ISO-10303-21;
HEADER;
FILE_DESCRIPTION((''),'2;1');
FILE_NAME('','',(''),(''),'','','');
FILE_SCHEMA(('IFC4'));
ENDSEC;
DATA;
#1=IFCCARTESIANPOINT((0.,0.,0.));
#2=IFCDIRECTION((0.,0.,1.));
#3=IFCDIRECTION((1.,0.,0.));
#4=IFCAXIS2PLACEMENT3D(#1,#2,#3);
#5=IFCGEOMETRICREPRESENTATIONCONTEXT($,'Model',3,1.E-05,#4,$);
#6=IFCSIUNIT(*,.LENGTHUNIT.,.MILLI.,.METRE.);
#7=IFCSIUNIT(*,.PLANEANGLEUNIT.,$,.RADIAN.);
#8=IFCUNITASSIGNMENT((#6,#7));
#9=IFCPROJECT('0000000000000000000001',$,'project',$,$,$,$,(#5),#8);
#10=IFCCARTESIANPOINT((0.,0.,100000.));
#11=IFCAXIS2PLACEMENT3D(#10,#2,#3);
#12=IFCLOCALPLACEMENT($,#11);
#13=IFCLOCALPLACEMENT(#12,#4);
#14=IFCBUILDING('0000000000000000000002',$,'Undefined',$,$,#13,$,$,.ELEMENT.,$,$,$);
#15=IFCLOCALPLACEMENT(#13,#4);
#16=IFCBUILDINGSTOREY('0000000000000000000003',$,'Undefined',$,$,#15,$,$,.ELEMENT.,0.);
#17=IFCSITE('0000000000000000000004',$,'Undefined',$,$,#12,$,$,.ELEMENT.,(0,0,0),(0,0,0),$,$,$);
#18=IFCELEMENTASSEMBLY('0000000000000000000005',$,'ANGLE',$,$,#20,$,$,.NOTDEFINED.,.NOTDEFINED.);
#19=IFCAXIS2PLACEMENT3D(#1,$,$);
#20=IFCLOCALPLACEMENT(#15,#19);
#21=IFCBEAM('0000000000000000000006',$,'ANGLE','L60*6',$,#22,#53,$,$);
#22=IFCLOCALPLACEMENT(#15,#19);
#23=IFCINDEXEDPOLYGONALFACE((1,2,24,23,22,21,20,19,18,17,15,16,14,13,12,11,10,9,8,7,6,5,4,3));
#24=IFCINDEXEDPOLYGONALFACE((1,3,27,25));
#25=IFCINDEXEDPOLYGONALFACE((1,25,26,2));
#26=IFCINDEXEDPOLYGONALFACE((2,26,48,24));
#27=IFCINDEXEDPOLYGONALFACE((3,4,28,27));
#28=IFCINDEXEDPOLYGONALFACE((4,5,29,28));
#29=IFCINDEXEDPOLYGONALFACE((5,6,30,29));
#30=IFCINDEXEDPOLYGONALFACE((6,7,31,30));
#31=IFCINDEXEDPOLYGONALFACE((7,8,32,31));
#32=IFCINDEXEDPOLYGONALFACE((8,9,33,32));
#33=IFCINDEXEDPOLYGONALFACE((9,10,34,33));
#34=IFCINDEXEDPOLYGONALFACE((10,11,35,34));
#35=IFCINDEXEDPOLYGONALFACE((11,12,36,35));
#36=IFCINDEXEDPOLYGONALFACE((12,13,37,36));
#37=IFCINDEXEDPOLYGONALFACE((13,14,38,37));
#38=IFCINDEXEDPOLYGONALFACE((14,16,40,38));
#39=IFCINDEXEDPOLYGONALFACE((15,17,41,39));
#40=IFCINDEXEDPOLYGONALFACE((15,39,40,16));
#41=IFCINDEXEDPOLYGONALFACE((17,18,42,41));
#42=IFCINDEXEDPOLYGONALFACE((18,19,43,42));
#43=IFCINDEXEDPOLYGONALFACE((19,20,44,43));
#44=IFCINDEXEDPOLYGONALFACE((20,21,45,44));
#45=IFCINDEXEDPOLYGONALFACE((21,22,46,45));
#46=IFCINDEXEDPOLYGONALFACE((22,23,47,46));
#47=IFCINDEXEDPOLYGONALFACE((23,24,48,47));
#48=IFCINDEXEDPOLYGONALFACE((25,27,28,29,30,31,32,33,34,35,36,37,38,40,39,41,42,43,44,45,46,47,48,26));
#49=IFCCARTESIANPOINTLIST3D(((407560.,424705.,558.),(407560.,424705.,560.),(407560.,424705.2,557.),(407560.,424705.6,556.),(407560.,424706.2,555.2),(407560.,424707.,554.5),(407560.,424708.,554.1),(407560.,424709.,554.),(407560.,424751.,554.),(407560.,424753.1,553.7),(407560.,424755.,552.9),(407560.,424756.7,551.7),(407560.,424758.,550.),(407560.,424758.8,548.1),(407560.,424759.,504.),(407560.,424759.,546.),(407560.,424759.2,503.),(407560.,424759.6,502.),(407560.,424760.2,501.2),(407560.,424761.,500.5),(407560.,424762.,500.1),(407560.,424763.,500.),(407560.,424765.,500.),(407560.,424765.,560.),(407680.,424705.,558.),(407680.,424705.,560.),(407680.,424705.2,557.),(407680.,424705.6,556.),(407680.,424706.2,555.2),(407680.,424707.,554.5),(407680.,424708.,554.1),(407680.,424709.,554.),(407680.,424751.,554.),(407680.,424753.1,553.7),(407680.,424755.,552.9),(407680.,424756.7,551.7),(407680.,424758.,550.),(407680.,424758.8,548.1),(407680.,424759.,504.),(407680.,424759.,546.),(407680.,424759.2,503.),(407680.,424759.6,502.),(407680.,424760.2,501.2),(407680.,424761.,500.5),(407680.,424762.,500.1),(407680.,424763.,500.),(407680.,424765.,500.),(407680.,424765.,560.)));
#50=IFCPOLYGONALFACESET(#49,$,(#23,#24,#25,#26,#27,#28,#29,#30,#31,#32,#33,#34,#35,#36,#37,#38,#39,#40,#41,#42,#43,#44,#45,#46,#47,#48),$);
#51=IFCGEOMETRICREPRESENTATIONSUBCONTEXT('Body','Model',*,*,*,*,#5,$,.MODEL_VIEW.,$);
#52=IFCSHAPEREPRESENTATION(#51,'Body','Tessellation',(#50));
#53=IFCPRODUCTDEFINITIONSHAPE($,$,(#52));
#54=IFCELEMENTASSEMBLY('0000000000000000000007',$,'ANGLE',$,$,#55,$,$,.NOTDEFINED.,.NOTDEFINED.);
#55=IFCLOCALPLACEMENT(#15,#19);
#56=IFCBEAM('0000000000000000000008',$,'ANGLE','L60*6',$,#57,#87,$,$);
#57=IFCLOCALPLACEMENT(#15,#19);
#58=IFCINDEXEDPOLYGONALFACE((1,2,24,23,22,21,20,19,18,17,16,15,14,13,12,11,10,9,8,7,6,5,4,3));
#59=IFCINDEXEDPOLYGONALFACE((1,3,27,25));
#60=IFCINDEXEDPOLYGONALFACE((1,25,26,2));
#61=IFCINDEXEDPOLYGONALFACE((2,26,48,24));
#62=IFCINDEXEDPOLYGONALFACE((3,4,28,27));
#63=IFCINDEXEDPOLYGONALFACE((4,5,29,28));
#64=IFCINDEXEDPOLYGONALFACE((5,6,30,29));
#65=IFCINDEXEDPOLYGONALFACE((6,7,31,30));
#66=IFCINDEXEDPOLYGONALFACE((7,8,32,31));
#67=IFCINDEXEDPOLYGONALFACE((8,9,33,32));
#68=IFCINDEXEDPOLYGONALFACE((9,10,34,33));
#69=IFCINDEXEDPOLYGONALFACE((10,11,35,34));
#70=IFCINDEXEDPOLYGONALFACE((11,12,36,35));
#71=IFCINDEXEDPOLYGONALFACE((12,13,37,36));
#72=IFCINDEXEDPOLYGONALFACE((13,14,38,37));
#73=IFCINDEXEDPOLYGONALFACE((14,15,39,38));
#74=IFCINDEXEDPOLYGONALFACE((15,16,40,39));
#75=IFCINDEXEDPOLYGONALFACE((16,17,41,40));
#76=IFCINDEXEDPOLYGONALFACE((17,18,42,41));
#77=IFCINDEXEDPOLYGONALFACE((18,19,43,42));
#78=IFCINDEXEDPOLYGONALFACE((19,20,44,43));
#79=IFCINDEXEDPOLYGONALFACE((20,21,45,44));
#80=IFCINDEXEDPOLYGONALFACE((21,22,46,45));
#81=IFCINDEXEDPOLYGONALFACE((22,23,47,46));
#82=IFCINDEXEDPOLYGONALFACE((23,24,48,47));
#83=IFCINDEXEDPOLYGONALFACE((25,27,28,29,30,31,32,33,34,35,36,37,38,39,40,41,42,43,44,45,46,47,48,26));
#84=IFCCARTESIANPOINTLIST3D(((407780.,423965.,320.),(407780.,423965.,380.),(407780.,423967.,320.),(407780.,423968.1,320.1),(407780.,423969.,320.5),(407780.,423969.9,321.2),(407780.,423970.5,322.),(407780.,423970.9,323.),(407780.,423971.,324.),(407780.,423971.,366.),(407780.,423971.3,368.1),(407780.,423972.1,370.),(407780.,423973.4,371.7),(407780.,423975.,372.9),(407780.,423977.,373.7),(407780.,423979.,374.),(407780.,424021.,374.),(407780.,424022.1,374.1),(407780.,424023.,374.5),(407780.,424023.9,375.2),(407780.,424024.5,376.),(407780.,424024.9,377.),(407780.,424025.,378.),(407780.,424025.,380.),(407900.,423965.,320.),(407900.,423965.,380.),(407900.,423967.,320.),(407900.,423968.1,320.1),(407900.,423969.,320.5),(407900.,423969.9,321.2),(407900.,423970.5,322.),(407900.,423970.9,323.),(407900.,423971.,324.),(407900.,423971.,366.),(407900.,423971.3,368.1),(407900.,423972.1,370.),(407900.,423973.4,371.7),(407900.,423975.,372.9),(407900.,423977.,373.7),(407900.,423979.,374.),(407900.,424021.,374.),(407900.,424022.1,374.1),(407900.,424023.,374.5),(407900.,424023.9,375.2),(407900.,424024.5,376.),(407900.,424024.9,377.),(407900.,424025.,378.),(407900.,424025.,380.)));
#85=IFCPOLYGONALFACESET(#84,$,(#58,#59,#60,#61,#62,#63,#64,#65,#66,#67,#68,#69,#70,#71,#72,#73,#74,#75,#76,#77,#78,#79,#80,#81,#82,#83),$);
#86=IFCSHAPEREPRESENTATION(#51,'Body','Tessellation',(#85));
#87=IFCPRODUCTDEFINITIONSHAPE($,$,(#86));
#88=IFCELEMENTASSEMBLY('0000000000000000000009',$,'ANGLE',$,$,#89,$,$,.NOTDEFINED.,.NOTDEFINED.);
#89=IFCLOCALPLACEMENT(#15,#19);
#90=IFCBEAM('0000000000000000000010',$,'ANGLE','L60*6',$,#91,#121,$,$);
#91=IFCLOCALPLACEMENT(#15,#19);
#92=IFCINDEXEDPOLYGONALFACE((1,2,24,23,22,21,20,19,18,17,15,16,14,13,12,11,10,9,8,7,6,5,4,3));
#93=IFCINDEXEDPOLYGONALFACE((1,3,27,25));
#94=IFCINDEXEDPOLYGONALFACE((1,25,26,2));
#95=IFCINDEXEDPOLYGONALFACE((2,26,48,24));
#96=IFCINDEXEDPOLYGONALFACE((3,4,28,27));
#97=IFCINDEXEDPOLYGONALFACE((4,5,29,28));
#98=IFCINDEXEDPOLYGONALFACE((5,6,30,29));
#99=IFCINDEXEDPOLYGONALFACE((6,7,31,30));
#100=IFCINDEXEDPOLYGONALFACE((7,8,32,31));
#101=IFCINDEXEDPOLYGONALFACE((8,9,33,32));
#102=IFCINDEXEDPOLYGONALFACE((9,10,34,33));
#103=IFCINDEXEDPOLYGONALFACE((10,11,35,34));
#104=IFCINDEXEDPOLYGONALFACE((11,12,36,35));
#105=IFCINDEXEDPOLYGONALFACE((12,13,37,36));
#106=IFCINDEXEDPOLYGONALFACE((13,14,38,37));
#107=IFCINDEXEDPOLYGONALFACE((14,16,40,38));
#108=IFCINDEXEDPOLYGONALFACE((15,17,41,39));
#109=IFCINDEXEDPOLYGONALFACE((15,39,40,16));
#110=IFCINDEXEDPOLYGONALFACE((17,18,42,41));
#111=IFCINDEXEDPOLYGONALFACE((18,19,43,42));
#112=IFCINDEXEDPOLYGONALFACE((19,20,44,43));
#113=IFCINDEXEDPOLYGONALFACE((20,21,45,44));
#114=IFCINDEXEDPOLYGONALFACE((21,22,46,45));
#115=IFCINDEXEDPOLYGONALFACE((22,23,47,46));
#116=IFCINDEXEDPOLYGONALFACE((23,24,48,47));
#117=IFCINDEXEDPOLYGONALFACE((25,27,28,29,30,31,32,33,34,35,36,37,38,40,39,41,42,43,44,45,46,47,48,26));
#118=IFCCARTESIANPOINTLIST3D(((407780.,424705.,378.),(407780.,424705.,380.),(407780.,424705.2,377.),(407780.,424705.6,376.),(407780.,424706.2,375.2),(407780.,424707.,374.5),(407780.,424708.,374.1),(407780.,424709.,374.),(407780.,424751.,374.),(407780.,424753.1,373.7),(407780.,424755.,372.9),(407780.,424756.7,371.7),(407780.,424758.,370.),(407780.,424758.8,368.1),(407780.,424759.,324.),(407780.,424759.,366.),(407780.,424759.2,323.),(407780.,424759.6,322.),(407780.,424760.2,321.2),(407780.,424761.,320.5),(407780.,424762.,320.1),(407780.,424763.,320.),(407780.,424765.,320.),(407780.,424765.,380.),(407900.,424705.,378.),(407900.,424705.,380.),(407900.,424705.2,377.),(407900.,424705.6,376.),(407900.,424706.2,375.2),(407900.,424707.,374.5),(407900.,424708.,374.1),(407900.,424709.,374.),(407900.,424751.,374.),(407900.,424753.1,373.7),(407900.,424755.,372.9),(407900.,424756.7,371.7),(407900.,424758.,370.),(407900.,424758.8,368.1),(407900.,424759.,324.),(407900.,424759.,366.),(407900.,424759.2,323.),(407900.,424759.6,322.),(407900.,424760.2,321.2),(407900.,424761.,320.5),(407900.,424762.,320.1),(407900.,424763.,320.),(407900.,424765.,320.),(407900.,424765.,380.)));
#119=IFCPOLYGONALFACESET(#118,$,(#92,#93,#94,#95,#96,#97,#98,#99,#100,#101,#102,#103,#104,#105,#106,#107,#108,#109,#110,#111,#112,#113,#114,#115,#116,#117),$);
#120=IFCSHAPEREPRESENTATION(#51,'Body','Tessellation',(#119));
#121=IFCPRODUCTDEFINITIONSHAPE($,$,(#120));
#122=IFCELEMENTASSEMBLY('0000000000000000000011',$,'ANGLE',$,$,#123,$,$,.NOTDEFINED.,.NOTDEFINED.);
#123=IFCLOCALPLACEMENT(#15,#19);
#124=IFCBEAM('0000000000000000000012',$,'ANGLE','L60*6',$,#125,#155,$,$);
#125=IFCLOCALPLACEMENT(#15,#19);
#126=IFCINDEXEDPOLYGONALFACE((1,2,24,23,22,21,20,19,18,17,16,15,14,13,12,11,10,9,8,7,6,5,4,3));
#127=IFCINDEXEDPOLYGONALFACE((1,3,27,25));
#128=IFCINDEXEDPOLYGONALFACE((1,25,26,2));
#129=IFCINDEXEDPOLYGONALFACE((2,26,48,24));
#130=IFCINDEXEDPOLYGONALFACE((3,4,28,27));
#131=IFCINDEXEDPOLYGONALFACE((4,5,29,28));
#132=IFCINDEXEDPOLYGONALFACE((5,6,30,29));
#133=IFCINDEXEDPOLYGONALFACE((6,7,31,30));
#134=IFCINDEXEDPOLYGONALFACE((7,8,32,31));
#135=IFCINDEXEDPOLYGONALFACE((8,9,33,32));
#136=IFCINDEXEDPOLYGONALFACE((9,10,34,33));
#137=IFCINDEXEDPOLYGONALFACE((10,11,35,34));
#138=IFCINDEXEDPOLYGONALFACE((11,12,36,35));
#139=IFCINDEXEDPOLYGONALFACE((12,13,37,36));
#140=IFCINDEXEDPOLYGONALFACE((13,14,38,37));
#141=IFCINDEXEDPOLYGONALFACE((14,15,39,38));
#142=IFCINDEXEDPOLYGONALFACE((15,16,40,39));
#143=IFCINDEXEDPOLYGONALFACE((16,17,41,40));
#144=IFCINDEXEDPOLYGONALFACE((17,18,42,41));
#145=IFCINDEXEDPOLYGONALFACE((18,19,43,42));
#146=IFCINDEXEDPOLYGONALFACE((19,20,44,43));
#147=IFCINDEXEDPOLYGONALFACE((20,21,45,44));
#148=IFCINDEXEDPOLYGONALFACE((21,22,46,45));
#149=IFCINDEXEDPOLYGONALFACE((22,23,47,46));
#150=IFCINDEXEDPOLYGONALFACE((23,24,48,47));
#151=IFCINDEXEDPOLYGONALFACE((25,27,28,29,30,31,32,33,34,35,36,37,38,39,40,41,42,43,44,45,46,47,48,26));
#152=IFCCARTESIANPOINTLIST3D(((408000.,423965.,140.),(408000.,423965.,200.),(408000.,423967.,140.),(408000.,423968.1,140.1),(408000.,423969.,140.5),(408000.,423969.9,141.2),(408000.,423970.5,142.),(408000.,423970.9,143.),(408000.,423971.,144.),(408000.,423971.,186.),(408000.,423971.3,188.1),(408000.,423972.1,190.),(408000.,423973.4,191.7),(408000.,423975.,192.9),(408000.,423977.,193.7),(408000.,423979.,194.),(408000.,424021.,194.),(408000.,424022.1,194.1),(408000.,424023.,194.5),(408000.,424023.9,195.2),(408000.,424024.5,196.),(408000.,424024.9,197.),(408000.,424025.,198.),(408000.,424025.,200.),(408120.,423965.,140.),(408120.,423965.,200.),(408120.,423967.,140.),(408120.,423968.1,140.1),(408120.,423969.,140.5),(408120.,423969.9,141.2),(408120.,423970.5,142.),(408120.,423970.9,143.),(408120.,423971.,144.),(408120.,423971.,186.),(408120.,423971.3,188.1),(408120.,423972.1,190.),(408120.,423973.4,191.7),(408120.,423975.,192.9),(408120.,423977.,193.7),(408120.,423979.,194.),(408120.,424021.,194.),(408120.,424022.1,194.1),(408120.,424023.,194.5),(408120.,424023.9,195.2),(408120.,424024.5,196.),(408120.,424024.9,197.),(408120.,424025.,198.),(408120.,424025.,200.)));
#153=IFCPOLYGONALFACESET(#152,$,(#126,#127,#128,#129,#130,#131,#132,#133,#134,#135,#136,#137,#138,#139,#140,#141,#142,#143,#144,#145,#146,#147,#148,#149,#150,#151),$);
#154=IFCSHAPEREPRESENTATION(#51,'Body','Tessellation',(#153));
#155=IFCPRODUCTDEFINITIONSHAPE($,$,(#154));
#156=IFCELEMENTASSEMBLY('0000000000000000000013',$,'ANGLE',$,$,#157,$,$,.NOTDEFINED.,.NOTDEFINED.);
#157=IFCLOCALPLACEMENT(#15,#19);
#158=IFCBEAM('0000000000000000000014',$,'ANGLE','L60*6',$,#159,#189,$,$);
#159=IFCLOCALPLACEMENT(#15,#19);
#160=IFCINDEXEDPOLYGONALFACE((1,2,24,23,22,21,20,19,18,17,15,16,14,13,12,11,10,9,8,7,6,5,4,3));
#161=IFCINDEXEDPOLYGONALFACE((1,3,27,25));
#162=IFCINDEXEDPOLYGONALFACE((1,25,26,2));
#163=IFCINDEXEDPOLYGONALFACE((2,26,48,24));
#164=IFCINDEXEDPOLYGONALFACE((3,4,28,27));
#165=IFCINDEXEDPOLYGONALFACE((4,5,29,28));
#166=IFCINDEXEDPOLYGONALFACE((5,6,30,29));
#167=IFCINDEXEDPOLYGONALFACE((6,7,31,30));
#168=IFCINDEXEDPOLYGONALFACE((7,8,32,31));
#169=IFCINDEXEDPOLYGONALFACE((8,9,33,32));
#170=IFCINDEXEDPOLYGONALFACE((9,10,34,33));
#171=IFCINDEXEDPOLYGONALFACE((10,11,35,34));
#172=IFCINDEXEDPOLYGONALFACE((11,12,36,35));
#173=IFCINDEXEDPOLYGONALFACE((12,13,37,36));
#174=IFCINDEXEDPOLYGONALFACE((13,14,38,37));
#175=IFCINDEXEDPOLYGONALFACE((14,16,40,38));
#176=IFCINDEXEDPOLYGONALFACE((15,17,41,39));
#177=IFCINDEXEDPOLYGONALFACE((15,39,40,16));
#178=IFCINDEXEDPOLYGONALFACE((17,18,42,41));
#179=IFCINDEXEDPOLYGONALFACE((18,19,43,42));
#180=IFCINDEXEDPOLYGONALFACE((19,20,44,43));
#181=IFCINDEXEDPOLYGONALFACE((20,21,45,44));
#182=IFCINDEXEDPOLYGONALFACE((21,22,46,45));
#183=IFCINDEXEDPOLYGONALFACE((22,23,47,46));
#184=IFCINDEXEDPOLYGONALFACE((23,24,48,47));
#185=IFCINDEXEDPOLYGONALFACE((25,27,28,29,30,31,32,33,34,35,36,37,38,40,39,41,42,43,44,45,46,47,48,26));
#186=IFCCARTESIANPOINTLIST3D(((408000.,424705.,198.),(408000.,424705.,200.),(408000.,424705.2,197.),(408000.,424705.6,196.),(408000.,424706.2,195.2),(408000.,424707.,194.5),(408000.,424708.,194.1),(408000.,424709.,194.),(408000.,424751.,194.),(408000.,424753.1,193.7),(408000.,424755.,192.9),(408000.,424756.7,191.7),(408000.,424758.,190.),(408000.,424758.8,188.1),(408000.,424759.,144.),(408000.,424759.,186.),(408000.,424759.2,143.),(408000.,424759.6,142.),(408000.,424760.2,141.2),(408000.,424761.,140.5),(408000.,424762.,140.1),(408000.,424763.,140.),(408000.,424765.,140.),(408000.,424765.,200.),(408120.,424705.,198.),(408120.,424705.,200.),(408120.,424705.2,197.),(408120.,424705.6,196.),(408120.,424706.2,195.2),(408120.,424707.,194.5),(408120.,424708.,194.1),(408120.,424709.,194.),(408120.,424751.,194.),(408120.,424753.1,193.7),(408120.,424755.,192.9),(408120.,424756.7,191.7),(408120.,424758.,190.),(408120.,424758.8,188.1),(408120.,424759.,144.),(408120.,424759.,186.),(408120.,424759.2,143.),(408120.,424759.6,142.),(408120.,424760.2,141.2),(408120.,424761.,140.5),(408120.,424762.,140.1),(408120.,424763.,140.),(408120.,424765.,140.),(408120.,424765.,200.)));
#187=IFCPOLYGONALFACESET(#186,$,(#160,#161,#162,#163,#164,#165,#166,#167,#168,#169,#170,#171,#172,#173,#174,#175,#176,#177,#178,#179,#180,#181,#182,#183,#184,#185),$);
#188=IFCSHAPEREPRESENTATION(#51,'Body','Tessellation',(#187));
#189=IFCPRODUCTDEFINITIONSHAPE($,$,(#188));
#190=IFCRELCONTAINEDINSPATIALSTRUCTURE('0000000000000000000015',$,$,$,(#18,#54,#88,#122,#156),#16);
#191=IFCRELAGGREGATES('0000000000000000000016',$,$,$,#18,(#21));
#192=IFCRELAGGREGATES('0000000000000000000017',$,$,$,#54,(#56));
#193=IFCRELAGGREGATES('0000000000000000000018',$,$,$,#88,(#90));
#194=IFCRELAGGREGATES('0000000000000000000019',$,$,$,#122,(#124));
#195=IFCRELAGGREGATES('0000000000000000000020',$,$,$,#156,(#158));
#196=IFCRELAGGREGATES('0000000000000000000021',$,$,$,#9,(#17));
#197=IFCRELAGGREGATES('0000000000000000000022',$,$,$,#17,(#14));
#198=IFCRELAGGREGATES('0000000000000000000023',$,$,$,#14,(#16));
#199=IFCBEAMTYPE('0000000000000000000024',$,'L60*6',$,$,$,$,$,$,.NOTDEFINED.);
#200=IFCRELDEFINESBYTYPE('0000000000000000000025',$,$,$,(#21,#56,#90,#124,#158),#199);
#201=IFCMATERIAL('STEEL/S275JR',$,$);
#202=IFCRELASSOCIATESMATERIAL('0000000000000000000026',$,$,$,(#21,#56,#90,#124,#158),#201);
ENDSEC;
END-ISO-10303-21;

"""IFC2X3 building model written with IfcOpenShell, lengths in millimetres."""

from ifc_helpers import new_model, si_unit, frame, origin_with_axes, origin_2d_with_axis, place, context, subcontext, project, spatial, l_section, extrude, material, type_object, element, aggregate, save


model = new_model("IFC2X3")

# Units and contexts
model_context = context("Model", 3, precision=1e-05, world=origin_with_axes())
body_context = subcontext(model_context, "Body", "Model", "MODEL_VIEW")
ifc_project = project(units=[si_unit("LENGTHUNIT", "METRE", prefix="MILLI"), si_unit("PLANEANGLEUNIT", "RADIAN")], contexts=[model_context])

# Site, building, storey
site_placement = place(None, frame((0.0, 0.0, 100000.0), z_axis=(0.0, 0.0, 1.0), x_axis=(1.0, 0.0, 0.0)))
site = spatial("IfcSite", under=ifc_project, at=site_placement, Name="Undefined", CompositionType="ELEMENT", RefLatitude=(0, 0, 0), RefLongitude=(0, 0, 0))
building_placement = place(site_placement, origin_with_axes())
building = spatial("IfcBuilding", under=site, at=building_placement, Name="Undefined", CompositionType="ELEMENT")
storey_placement = place(building_placement, origin_with_axes())
storey = spatial("IfcBuildingStorey", under=building, at=storey_placement, Name="Undefined", CompositionType="ELEMENT", Elevation=0.0)

# Shared definitions
ifc_material_1 = material(Name="STEEL/S275JR")

# Element assemblies, beams
beam_type_1 = type_object("IfcBeamType", Name="L60*6", PredefinedType="NOTDEFINED")
assembly_1_placement = place(storey_placement, origin_with_axes())
assembly_1 = element("IfcElementAssembly", 1, at=assembly_1_placement, inside=storey, Name="ANGLE", AssemblyPlace="NOTDEFINED", PredefinedType="NOTDEFINED")
beam_1_placement = place(assembly_1_placement, frame((407560.0, 424735.0, 530.0), z_axis=(0.0, -1.0, 0.0), x_axis=(1.0, 0.0, 0.0)))
beam_1 = element("IfcBeam", 2, at=beam_1_placement, type_object=beam_type_1, material=ifc_material_1, Name="ANGLE", Description="L60*6", context=body_context, shape_type="SweptSolid", body=[
    extrude(l_section(Depth=60.0, Width=60.0, Thickness=6.0, FilletRadius=8.0, EdgeRadius=4.0, at=origin_2d_with_axis()), frame((120.0, 0.0, 0.0), z_axis=(-1.0, 0.0, 0.0), x_axis=(0.0, -1.0, 0.0)), (0.0, 0.0, 1.0), 120.0),
])
assembly_2_placement = place(storey_placement, origin_with_axes())
assembly_2 = element("IfcElementAssembly", 3, at=assembly_2_placement, inside=storey, Name="ANGLE", AssemblyPlace="NOTDEFINED", PredefinedType="NOTDEFINED")
beam_2_placement = place(assembly_2_placement, frame((407900.0, 423995.0, 350.0), z_axis=(0.0, 1.0, 0.0), x_axis=(-1.0, 0.0, 0.0)))
beam_2 = element("IfcBeam", 4, at=beam_2_placement, type_object=beam_type_1, material=ifc_material_1, Name="ANGLE", Description="L60*6", context=body_context, shape_type="SweptSolid", body=[
    extrude(l_section(Depth=60.0, Width=60.0, Thickness=6.0, FilletRadius=8.0, EdgeRadius=4.0, at=origin_2d_with_axis()), frame((120.0, 0.0, 0.0), z_axis=(-1.0, 0.0, 0.0), x_axis=(0.0, -1.0, 0.0)), (0.0, 0.0, 1.0), 120.0),
])
assembly_3_placement = place(storey_placement, origin_with_axes())
assembly_3 = element("IfcElementAssembly", 5, at=assembly_3_placement, inside=storey, Name="ANGLE", AssemblyPlace="NOTDEFINED", PredefinedType="NOTDEFINED")
beam_3_placement = place(assembly_3_placement, frame((407780.0, 424735.0, 350.0), z_axis=(0.0, -1.0, 0.0), x_axis=(1.0, 0.0, 0.0)))
beam_3 = element("IfcBeam", 6, at=beam_3_placement, type_object=beam_type_1, material=ifc_material_1, Name="ANGLE", Description="L60*6", context=body_context, shape_type="SweptSolid", body=[
    extrude(l_section(Depth=60.0, Width=60.0, Thickness=6.0, FilletRadius=8.0, EdgeRadius=4.0, at=origin_2d_with_axis()), frame((120.0, 0.0, 0.0), z_axis=(-1.0, 0.0, 0.0), x_axis=(0.0, -1.0, 0.0)), (0.0, 0.0, 1.0), 120.0),
])
assembly_4_placement = place(storey_placement, origin_with_axes())
assembly_4 = element("IfcElementAssembly", 7, at=assembly_4_placement, inside=storey, Name="ANGLE", AssemblyPlace="NOTDEFINED", PredefinedType="NOTDEFINED")
beam_4_placement = place(assembly_4_placement, frame((408120.0, 423995.0, 170.0), z_axis=(0.0, 1.0, 0.0), x_axis=(-1.0, 0.0, 0.0)))
beam_4 = element("IfcBeam", 8, at=beam_4_placement, type_object=beam_type_1, material=ifc_material_1, Name="ANGLE", Description="L60*6", context=body_context, shape_type="SweptSolid", body=[
    extrude(l_section(Depth=60.0, Width=60.0, Thickness=6.0, FilletRadius=8.0, EdgeRadius=4.0, at=origin_2d_with_axis()), frame((120.0, 0.0, 0.0), z_axis=(-1.0, 0.0, 0.0), x_axis=(0.0, -1.0, 0.0)), (0.0, 0.0, 1.0), 120.0),
])
assembly_5_placement = place(storey_placement, origin_with_axes())
assembly_5 = element("IfcElementAssembly", 9, at=assembly_5_placement, inside=storey, Name="ANGLE", AssemblyPlace="NOTDEFINED", PredefinedType="NOTDEFINED")
beam_5_placement = place(assembly_5_placement, frame((408000.0, 424735.0, 170.0), z_axis=(0.0, -1.0, 0.0), x_axis=(1.0, 0.0, 0.0)))
beam_5 = element("IfcBeam", 10, at=beam_5_placement, type_object=beam_type_1, material=ifc_material_1, Name="ANGLE", Description="L60*6", context=body_context, shape_type="SweptSolid", body=[
    extrude(l_section(Depth=60.0, Width=60.0, Thickness=6.0, FilletRadius=8.0, EdgeRadius=4.0, at=origin_2d_with_axis()), frame((120.0, 0.0, 0.0), z_axis=(-1.0, 0.0, 0.0), x_axis=(0.0, -1.0, 0.0)), (0.0, 0.0, 1.0), 120.0),
])

aggregate(assembly_1, [beam_1])
aggregate(assembly_2, [beam_2])
aggregate(assembly_3, [beam_3])
aggregate(assembly_4, [beam_4])
aggregate(assembly_5, [beam_5])

save(model, "model.ifc")
